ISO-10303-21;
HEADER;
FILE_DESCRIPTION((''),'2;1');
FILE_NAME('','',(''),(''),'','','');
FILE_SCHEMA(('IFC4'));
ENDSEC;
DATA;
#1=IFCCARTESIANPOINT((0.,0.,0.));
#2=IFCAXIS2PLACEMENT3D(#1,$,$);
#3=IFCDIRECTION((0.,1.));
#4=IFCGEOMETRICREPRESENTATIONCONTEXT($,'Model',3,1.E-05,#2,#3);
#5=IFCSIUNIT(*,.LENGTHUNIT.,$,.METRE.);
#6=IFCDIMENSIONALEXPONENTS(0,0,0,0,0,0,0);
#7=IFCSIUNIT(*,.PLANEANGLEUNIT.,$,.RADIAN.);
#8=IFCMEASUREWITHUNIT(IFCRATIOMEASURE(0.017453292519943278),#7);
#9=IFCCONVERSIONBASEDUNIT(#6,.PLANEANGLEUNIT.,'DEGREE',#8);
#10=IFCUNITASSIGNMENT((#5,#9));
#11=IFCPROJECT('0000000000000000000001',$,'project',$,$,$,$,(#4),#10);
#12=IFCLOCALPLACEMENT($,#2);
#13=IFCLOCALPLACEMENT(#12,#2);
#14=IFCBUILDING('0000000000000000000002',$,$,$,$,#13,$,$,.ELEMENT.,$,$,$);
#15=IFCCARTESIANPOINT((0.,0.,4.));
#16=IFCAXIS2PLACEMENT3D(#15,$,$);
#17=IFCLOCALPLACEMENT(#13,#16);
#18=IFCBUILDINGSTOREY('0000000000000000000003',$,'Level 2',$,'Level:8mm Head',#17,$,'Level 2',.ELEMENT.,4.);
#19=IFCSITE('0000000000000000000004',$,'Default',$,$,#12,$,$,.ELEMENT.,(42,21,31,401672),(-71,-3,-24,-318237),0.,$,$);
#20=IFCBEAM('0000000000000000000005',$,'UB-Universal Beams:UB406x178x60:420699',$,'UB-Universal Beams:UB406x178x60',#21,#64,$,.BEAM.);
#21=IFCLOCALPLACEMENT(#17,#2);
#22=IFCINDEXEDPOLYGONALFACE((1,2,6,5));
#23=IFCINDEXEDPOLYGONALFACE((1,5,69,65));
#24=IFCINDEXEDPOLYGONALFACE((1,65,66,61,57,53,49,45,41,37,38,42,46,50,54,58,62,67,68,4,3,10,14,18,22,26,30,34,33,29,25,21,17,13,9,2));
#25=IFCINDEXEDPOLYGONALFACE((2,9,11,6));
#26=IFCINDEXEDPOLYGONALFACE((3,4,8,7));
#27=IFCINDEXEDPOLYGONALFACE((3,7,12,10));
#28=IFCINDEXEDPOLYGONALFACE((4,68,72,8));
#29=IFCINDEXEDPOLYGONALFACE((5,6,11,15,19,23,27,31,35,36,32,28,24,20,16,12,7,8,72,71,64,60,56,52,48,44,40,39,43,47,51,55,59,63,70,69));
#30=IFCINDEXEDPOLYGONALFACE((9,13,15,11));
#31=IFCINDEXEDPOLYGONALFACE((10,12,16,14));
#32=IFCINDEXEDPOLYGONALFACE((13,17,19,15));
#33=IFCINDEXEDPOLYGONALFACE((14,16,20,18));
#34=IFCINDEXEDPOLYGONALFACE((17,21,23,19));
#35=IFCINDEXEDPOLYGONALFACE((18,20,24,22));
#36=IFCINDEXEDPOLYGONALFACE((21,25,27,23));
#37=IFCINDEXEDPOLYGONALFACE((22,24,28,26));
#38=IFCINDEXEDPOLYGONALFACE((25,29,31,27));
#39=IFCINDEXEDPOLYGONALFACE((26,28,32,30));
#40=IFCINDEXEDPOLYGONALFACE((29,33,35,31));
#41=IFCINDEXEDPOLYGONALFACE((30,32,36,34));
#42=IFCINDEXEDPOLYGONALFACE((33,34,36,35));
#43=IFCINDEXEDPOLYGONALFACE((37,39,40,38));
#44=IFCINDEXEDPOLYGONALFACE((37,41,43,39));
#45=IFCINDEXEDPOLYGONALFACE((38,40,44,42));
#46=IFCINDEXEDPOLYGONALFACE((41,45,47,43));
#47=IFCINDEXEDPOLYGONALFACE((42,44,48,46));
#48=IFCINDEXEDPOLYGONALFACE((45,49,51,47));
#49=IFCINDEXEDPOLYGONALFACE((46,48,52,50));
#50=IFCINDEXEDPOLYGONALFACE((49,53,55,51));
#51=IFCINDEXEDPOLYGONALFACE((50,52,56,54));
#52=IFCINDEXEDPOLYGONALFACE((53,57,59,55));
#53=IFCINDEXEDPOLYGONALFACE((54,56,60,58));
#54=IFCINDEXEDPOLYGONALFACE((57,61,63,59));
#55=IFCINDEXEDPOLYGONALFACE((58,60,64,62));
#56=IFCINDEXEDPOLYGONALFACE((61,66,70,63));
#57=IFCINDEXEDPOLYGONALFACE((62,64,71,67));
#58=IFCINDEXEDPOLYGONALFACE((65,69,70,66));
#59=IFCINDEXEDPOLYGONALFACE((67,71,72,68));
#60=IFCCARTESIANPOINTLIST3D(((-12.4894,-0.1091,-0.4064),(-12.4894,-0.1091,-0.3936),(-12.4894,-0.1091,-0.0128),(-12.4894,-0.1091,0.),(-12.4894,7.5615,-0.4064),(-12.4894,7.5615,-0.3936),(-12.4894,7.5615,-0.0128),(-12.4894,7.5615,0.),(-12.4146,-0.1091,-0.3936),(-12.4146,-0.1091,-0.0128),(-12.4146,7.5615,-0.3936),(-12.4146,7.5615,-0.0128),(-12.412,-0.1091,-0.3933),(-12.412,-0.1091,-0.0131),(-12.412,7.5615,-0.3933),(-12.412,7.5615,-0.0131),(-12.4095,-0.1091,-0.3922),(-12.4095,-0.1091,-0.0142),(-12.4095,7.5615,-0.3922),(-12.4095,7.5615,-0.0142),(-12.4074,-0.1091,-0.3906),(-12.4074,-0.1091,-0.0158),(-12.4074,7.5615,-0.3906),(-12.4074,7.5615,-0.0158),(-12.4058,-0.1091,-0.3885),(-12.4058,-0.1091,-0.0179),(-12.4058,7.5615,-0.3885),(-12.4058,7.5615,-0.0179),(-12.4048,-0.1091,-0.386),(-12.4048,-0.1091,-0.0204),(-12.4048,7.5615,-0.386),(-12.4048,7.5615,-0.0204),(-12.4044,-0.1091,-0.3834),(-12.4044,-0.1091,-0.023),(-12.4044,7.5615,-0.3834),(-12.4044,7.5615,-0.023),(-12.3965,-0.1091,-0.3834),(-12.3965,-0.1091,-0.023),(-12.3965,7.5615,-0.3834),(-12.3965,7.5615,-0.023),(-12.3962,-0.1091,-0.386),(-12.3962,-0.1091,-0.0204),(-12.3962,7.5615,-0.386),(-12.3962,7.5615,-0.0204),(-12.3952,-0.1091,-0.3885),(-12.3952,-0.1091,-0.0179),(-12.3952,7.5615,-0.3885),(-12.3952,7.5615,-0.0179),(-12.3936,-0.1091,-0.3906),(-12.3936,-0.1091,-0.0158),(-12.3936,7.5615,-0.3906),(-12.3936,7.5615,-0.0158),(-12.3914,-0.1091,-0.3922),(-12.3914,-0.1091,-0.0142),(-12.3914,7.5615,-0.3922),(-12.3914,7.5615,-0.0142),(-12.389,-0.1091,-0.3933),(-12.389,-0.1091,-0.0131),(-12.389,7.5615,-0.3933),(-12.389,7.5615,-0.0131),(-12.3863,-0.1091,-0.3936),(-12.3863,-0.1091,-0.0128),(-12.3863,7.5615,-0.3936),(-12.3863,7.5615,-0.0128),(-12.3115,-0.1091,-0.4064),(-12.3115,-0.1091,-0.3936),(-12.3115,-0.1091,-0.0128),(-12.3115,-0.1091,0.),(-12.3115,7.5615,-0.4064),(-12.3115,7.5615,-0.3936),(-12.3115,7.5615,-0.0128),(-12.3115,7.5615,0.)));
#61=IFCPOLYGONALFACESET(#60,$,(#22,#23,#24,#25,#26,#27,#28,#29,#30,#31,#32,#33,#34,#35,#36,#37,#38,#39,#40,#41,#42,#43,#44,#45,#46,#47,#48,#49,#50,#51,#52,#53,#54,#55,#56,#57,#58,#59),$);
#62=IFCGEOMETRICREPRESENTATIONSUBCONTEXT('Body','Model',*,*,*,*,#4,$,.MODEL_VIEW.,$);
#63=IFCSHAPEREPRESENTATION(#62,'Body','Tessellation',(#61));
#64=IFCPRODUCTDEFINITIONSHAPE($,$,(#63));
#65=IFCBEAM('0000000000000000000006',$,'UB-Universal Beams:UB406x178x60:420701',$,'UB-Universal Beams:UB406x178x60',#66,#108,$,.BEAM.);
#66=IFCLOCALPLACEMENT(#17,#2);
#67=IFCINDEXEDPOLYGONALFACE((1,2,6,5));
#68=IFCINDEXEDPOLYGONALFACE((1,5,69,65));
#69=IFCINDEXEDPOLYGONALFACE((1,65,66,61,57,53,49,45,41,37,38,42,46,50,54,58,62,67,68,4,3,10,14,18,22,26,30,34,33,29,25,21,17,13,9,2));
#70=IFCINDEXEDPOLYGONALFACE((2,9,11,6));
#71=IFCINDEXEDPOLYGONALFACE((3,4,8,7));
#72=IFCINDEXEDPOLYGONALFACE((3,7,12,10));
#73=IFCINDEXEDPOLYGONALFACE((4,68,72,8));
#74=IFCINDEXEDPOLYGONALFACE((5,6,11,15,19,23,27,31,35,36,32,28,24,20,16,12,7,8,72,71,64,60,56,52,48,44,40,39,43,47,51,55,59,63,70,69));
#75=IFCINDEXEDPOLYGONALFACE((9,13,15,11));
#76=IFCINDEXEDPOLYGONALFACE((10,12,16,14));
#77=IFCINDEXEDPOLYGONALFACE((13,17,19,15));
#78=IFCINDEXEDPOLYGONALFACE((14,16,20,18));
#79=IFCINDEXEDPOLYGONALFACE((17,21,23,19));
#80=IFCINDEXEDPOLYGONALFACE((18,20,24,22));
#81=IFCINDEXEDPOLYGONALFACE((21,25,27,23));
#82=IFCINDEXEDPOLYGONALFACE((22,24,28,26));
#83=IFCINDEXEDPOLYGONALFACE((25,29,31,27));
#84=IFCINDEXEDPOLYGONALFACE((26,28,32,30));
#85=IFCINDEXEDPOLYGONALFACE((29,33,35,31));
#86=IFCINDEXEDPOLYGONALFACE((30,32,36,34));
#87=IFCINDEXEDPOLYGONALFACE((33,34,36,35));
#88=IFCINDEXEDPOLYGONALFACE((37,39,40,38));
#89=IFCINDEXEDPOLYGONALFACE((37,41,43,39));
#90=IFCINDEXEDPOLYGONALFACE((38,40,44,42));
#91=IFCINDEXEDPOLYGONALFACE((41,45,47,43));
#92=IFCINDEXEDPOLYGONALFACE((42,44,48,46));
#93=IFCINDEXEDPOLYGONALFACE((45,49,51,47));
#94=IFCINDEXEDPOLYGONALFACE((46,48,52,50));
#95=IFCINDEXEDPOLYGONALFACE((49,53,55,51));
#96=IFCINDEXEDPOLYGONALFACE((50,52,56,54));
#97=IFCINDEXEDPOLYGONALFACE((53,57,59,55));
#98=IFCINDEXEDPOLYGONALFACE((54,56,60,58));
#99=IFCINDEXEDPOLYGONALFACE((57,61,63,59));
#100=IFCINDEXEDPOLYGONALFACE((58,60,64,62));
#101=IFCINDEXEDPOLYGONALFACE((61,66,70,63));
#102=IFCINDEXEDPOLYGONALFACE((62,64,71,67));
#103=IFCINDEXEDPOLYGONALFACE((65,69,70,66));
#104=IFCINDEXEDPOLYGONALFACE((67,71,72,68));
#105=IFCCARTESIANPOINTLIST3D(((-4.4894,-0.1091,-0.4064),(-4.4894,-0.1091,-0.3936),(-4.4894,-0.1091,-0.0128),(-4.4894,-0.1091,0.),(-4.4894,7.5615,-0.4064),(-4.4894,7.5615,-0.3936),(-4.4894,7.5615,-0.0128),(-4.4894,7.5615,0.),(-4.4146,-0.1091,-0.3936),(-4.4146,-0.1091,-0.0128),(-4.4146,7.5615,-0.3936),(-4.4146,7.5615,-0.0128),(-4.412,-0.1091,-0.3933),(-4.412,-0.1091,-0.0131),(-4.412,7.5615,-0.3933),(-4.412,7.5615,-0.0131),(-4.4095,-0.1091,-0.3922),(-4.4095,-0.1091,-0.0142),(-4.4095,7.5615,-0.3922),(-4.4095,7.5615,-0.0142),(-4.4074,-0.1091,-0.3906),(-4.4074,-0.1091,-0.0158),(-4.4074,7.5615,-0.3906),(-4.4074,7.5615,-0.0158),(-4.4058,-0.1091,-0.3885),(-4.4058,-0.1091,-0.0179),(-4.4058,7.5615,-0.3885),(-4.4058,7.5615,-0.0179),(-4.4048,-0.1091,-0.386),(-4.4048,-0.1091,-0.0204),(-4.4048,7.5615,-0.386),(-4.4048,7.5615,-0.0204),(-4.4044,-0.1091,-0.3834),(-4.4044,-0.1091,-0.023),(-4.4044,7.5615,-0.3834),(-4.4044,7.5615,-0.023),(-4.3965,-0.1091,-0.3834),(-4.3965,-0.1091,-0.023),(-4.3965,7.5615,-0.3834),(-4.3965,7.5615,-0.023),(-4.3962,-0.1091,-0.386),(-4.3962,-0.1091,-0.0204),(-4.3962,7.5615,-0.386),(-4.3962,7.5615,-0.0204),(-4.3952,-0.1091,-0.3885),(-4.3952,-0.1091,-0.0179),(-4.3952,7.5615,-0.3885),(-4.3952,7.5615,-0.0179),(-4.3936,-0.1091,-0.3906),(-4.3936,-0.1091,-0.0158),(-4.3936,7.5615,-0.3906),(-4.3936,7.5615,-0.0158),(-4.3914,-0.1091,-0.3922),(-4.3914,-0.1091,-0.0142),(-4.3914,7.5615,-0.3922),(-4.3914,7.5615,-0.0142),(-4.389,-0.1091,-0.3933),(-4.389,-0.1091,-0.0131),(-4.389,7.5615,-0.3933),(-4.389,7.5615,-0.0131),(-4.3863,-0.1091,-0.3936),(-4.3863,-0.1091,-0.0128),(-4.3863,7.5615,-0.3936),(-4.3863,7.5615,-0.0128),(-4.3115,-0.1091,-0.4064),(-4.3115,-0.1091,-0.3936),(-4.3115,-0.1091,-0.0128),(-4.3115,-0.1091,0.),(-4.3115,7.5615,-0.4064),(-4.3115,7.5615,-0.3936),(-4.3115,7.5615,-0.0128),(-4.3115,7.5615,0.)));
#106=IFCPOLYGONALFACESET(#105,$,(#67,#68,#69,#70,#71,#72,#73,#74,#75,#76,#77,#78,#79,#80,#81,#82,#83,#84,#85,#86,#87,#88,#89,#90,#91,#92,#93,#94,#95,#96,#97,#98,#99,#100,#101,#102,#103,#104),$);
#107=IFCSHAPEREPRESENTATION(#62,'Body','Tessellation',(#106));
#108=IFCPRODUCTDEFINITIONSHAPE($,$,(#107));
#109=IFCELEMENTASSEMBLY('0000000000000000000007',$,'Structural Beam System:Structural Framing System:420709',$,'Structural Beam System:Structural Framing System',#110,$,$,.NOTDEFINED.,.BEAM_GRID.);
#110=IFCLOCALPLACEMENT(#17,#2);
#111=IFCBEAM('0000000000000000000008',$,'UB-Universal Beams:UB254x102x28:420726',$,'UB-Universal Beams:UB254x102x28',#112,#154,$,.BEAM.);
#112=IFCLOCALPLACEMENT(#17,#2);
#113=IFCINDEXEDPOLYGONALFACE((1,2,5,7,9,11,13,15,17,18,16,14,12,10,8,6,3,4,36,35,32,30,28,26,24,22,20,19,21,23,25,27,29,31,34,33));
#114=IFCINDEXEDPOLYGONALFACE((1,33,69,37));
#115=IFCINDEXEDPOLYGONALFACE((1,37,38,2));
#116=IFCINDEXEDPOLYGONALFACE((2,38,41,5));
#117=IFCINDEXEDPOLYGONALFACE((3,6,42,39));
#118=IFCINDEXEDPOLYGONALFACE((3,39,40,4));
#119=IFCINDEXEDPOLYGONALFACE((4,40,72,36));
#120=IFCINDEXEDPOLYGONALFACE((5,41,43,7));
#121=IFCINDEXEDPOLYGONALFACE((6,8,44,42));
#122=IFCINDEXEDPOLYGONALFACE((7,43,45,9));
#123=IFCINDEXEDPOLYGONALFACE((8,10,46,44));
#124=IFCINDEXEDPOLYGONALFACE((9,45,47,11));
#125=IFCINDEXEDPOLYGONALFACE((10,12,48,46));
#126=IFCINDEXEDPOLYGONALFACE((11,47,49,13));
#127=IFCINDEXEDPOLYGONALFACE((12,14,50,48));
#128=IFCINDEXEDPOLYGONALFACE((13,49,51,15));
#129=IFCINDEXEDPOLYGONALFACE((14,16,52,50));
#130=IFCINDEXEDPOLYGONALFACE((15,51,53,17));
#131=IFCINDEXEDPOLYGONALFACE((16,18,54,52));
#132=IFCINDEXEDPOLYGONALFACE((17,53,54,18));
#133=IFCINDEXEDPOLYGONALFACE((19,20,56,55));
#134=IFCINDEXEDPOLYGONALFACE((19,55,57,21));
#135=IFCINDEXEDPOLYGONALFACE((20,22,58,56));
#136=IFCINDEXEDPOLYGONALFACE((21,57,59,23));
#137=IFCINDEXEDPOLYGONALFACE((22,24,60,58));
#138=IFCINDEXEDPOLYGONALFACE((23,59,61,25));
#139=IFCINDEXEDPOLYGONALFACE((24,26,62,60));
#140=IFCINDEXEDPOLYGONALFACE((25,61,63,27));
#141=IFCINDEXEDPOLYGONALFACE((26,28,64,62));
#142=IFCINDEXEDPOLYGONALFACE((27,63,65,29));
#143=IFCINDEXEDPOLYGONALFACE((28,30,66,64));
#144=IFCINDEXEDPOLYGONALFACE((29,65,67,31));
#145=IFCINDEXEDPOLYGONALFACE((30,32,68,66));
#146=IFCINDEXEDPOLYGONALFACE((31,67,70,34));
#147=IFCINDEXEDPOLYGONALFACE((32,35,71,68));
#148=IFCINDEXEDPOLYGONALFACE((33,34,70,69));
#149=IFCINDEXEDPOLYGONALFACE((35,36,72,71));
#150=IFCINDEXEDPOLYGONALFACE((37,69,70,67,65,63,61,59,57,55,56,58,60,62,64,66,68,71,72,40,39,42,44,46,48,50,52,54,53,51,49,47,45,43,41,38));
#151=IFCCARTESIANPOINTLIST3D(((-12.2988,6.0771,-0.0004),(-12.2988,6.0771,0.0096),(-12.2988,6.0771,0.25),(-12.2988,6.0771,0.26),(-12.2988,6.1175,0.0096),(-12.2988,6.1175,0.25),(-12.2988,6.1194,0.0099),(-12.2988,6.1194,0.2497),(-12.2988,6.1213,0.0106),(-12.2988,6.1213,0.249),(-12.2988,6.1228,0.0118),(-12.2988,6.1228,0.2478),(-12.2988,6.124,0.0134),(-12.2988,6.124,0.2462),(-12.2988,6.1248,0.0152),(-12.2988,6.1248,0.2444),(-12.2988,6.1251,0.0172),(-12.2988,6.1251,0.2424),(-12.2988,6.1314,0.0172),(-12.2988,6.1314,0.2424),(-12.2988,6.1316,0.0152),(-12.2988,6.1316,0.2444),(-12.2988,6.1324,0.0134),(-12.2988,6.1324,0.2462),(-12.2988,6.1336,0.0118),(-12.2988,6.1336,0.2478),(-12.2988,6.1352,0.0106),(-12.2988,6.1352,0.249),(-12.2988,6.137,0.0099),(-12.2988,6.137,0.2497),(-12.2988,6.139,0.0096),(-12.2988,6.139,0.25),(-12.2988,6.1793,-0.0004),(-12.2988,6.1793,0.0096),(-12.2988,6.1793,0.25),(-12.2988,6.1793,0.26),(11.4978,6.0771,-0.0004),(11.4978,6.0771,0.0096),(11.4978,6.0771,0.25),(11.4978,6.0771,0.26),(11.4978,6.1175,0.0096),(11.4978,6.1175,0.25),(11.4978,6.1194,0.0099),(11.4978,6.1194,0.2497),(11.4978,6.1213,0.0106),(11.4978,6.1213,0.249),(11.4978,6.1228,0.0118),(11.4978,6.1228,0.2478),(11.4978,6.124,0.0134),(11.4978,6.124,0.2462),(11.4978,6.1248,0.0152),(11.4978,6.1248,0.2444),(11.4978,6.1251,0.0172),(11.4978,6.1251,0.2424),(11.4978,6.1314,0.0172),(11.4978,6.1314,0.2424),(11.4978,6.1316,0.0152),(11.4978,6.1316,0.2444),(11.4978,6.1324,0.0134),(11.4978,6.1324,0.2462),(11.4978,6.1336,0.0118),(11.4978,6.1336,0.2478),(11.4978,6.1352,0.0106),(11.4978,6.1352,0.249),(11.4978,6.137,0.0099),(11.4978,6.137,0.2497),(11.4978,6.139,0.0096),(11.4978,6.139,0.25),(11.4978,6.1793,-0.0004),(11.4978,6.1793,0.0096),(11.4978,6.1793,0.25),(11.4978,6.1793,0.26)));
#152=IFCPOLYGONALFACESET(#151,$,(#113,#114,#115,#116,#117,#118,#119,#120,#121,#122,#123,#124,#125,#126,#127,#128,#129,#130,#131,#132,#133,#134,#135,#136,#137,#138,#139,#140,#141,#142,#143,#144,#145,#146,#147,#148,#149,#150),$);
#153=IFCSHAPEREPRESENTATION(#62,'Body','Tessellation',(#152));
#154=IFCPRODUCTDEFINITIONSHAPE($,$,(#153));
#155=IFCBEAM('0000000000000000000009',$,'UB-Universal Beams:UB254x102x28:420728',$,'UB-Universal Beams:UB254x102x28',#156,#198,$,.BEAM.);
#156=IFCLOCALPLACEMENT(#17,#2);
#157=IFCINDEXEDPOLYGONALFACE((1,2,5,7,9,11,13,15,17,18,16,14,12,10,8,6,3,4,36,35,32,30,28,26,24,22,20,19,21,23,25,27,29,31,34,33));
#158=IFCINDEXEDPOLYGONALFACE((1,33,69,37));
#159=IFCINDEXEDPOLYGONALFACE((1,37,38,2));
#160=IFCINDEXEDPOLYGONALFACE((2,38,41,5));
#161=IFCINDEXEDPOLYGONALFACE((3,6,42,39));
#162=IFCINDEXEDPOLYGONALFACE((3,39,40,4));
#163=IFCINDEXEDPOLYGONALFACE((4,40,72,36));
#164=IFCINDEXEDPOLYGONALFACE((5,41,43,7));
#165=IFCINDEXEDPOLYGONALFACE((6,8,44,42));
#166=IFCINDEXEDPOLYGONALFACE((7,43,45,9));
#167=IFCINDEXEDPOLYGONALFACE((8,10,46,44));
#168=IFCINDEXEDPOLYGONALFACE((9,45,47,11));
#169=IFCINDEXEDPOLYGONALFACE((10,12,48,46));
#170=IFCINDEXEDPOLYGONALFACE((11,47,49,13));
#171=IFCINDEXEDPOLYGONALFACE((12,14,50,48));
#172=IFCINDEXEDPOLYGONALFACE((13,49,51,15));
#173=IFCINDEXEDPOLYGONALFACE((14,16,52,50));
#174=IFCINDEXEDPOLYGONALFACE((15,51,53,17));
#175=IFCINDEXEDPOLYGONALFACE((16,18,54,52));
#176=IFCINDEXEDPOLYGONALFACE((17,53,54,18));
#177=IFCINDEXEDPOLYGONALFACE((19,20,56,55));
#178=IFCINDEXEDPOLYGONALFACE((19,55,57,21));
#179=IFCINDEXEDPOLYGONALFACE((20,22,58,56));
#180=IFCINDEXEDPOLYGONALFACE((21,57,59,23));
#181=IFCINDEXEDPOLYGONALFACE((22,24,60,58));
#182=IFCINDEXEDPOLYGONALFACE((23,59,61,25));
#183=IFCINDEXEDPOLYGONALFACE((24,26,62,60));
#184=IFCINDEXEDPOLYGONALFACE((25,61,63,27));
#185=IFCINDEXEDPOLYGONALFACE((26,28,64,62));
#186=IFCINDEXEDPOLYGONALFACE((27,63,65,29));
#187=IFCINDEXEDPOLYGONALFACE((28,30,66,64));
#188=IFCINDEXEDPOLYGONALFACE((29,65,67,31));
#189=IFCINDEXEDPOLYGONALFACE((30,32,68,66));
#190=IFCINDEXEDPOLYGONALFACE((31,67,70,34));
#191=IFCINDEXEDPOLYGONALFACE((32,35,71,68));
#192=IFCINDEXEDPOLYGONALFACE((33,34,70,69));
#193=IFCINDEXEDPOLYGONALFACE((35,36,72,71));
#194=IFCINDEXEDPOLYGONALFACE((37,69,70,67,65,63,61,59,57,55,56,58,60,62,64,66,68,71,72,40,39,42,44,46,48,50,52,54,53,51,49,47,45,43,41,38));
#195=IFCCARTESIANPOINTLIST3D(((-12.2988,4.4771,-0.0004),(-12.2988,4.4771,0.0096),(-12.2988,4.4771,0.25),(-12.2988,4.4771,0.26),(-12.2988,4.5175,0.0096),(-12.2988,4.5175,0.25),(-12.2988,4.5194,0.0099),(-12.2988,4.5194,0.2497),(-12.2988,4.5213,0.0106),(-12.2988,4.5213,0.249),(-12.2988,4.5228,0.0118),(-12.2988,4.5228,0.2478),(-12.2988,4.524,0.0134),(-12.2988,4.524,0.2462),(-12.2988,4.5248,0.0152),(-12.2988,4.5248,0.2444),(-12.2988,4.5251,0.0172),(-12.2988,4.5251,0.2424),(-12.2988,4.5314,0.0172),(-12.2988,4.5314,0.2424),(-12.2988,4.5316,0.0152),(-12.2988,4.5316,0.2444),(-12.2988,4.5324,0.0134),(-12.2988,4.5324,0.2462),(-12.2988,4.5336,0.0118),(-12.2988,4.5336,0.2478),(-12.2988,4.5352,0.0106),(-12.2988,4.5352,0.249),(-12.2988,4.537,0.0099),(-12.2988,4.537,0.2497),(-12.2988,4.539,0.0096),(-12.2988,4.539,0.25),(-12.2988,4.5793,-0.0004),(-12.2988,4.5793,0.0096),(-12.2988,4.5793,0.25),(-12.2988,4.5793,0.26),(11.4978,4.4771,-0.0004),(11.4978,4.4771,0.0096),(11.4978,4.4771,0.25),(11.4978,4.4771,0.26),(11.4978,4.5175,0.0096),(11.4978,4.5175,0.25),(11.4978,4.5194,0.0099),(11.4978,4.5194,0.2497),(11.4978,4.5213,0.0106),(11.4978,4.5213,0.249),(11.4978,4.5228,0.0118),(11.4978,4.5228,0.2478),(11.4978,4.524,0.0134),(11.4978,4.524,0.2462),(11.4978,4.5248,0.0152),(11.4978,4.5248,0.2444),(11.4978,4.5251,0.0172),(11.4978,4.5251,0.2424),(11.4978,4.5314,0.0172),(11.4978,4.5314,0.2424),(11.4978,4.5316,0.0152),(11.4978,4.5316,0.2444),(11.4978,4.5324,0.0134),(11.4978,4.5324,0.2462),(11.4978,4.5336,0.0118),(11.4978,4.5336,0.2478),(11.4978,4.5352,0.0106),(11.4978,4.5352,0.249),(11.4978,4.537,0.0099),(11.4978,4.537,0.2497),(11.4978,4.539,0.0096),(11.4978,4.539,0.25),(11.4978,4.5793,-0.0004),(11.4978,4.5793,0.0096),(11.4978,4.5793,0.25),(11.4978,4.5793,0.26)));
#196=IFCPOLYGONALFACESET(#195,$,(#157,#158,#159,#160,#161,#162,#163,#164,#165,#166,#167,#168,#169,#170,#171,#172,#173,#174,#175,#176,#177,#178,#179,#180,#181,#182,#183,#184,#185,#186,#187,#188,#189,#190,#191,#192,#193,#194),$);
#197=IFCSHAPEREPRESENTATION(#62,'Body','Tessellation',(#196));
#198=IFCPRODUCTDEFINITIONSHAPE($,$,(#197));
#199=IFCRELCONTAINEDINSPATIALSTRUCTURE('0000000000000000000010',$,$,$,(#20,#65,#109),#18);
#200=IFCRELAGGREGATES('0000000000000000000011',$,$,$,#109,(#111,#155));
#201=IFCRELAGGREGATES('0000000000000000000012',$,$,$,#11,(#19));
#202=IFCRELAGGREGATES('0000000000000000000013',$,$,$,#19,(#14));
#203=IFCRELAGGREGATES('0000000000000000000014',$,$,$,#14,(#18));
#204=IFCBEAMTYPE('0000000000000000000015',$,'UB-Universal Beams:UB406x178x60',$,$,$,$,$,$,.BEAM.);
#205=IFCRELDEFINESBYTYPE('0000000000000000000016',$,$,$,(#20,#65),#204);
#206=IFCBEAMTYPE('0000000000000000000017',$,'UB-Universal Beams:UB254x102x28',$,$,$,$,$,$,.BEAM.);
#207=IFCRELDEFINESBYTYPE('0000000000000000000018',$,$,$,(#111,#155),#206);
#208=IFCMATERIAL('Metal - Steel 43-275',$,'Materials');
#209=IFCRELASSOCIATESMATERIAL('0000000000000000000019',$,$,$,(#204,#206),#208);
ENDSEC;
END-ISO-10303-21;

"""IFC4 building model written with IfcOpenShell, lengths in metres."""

from ifc_helpers import new_model, entity, si_unit, converted_unit, direction, frame, frame_2d, origin, place, context, subcontext, project, spatial, i_section, extrude, source, transform, mapped, material, material_profile, profile_set, type_object, type_shapes, element, aggregate, save


model = new_model("IFC4")

# Units and contexts
model_context = context("Model", 3, precision=1e-05, world=origin(), true_north=direction((0.0, 1.0)))
body_context = subcontext(model_context, "Body", "Model", "MODEL_VIEW")
ifc_project = project(units=[si_unit("LENGTHUNIT", "METRE"), converted_unit("PLANEANGLEUNIT", "DEGREE", entity("IfcRatioMeasure", 0.017453292519943278), si_unit("PLANEANGLEUNIT", "RADIAN"), dimensions=[0, 0, 0, 0, 0, 0, 0])], contexts=[model_context])

# Site, building, storey
site_placement = place(None, origin())
site = spatial("IfcSite", under=ifc_project, at=site_placement, Name="Default", CompositionType="ELEMENT", RefLatitude=(42, 21, 31, 401672), RefLongitude=(-71, -3, -24, -318237), RefElevation=0.0)
building_placement = place(site_placement, origin())
building = spatial("IfcBuilding", under=site, at=building_placement, CompositionType="ELEMENT")
storey_placement = place(building_placement, frame((0.0, 0.0, 4.0)))
storey = spatial("IfcBuildingStorey", under=building, at=storey_placement, Name="Level 2", ObjectType="Level:8mm Head", LongName="Level 2", CompositionType="ELEMENT", Elevation=4.0)

# Beams
ifc_material_1 = material(Name="Metal - Steel 43-275", Category="Materials")
ifc_material_profile_1 = material_profile(ifc_material_1, i_section(OverallWidth=0.1779, OverallDepth=0.4064, WebThickness=0.0079, FlangeThickness=0.0128, FilletRadius=0.0102, at=frame_2d((0.0, 0.0), x_axis=(0.0, 1.0))), Name="UB406x178x60")
ifc_profile_set_1 = profile_set([ifc_material_profile_1], Name="UB406x178x60")
beam_type_1 = type_object("IfcBeamType", Name="UB-Universal Beams:UB406x178x60", PredefinedType="BEAM", material=ifc_profile_set_1)
shared_shape_1 = source(origin(), body_context, "Body", "SweptSolid", [
    extrude(i_section(OverallWidth=0.1779, OverallDepth=0.4064, WebThickness=0.0079, FlangeThickness=0.0128, FilletRadius=0.0102, at=frame_2d((0.0, 0.0), x_axis=(0.0, 1.0))), frame((-3.8373, 0.0, 0.0), z_axis=(1.0, 0.0, 0.0), x_axis=(0.0, 0.0, -1.0)), (0.0, 0.0, 1.0), 7.6706),
])
type_shapes(beam_type_1, [shared_shape_1])
for number, where, z_axis, x_axis, name in (
    (1, (-12.4005, 3.7282, -0.2032), (0.0, 0.0, 1.0), (0.0, 1.0, 0.0), "UB-Universal Beams:UB406x178x60:420699"),
    (2, (-4.4005, 3.7282, -0.2032), (0.0, 0.0, 1.0), (0.0, 1.0, 0.0), "UB-Universal Beams:UB406x178x60:420701"),
):
    element("IfcBeam", number, at=place(storey_placement, frame(where, z_axis=z_axis, x_axis=x_axis)), inside=storey, type_object=beam_type_1, Name=name, ObjectType="UB-Universal Beams:UB406x178x60", PredefinedType="BEAM", context=body_context, shape_type="MappedRepresentation", body=[
        mapped(shared_shape_1, transform((0.0, 0.0, 0.0), scale=1.0)),
    ])

# Element assembly, beams
assembly_placement = place(storey_placement, origin())
assembly = element("IfcElementAssembly", 3, at=assembly_placement, inside=storey, Name="Structural Beam System:Structural Framing System:420709", ObjectType="Structural Beam System:Structural Framing System", AssemblyPlace="NOTDEFINED", PredefinedType="BEAM_GRID")
ifc_material_profile_2 = material_profile(ifc_material_1, i_section(OverallWidth=0.1022, OverallDepth=0.2604, WebThickness=0.0063, FlangeThickness=0.01, FilletRadius=0.0076, at=frame_2d((0.0, 0.0), x_axis=(0.0, 1.0))), Name="UB254x102x28")
ifc_profile_set_2 = profile_set([ifc_material_profile_2], Name="UB254x102x28")
beam_type_2 = type_object("IfcBeamType", Name="UB-Universal Beams:UB254x102x28", PredefinedType="BEAM", material=ifc_profile_set_2)
shared_shape_2 = source(origin(), body_context, "Body", "SweptSolid", [
    extrude(i_section(OverallWidth=0.1022, OverallDepth=0.2604, WebThickness=0.0063, FlangeThickness=0.01, FilletRadius=0.0076, at=frame_2d((0.0, 0.0), x_axis=(0.0, 1.0))), frame((-11.8983, 0.0, 0.0), z_axis=(1.0, 0.0, 0.0), x_axis=(0.0, 0.0, -1.0)), (0.0, 0.0, 1.0), 23.7966),
])
type_shapes(beam_type_2, [shared_shape_2])
beam_1_placement = place(assembly_placement, frame((-0.4005, 6.1282, 0.1298)))
beam_1 = element("IfcBeam", 4, at=beam_1_placement, type_object=beam_type_2, Name="UB-Universal Beams:UB254x102x28:420726", ObjectType="UB-Universal Beams:UB254x102x28", PredefinedType="BEAM", context=body_context, shape_type="MappedRepresentation", body=[
    mapped(shared_shape_2, transform((0.0, 0.0, 0.0), scale=1.0)),
])
beam_2_placement = place(assembly_placement, frame((-0.4005, 4.5282, 0.1298)))
beam_2 = element("IfcBeam", 5, at=beam_2_placement, type_object=beam_type_2, Name="UB-Universal Beams:UB254x102x28:420728", ObjectType="UB-Universal Beams:UB254x102x28", PredefinedType="BEAM", context=body_context, shape_type="MappedRepresentation", body=[
    mapped(shared_shape_2, transform((0.0, 0.0, 0.0), scale=1.0)),
])
aggregate(assembly, [beam_1, beam_2])

save(model, "model.ifc")
